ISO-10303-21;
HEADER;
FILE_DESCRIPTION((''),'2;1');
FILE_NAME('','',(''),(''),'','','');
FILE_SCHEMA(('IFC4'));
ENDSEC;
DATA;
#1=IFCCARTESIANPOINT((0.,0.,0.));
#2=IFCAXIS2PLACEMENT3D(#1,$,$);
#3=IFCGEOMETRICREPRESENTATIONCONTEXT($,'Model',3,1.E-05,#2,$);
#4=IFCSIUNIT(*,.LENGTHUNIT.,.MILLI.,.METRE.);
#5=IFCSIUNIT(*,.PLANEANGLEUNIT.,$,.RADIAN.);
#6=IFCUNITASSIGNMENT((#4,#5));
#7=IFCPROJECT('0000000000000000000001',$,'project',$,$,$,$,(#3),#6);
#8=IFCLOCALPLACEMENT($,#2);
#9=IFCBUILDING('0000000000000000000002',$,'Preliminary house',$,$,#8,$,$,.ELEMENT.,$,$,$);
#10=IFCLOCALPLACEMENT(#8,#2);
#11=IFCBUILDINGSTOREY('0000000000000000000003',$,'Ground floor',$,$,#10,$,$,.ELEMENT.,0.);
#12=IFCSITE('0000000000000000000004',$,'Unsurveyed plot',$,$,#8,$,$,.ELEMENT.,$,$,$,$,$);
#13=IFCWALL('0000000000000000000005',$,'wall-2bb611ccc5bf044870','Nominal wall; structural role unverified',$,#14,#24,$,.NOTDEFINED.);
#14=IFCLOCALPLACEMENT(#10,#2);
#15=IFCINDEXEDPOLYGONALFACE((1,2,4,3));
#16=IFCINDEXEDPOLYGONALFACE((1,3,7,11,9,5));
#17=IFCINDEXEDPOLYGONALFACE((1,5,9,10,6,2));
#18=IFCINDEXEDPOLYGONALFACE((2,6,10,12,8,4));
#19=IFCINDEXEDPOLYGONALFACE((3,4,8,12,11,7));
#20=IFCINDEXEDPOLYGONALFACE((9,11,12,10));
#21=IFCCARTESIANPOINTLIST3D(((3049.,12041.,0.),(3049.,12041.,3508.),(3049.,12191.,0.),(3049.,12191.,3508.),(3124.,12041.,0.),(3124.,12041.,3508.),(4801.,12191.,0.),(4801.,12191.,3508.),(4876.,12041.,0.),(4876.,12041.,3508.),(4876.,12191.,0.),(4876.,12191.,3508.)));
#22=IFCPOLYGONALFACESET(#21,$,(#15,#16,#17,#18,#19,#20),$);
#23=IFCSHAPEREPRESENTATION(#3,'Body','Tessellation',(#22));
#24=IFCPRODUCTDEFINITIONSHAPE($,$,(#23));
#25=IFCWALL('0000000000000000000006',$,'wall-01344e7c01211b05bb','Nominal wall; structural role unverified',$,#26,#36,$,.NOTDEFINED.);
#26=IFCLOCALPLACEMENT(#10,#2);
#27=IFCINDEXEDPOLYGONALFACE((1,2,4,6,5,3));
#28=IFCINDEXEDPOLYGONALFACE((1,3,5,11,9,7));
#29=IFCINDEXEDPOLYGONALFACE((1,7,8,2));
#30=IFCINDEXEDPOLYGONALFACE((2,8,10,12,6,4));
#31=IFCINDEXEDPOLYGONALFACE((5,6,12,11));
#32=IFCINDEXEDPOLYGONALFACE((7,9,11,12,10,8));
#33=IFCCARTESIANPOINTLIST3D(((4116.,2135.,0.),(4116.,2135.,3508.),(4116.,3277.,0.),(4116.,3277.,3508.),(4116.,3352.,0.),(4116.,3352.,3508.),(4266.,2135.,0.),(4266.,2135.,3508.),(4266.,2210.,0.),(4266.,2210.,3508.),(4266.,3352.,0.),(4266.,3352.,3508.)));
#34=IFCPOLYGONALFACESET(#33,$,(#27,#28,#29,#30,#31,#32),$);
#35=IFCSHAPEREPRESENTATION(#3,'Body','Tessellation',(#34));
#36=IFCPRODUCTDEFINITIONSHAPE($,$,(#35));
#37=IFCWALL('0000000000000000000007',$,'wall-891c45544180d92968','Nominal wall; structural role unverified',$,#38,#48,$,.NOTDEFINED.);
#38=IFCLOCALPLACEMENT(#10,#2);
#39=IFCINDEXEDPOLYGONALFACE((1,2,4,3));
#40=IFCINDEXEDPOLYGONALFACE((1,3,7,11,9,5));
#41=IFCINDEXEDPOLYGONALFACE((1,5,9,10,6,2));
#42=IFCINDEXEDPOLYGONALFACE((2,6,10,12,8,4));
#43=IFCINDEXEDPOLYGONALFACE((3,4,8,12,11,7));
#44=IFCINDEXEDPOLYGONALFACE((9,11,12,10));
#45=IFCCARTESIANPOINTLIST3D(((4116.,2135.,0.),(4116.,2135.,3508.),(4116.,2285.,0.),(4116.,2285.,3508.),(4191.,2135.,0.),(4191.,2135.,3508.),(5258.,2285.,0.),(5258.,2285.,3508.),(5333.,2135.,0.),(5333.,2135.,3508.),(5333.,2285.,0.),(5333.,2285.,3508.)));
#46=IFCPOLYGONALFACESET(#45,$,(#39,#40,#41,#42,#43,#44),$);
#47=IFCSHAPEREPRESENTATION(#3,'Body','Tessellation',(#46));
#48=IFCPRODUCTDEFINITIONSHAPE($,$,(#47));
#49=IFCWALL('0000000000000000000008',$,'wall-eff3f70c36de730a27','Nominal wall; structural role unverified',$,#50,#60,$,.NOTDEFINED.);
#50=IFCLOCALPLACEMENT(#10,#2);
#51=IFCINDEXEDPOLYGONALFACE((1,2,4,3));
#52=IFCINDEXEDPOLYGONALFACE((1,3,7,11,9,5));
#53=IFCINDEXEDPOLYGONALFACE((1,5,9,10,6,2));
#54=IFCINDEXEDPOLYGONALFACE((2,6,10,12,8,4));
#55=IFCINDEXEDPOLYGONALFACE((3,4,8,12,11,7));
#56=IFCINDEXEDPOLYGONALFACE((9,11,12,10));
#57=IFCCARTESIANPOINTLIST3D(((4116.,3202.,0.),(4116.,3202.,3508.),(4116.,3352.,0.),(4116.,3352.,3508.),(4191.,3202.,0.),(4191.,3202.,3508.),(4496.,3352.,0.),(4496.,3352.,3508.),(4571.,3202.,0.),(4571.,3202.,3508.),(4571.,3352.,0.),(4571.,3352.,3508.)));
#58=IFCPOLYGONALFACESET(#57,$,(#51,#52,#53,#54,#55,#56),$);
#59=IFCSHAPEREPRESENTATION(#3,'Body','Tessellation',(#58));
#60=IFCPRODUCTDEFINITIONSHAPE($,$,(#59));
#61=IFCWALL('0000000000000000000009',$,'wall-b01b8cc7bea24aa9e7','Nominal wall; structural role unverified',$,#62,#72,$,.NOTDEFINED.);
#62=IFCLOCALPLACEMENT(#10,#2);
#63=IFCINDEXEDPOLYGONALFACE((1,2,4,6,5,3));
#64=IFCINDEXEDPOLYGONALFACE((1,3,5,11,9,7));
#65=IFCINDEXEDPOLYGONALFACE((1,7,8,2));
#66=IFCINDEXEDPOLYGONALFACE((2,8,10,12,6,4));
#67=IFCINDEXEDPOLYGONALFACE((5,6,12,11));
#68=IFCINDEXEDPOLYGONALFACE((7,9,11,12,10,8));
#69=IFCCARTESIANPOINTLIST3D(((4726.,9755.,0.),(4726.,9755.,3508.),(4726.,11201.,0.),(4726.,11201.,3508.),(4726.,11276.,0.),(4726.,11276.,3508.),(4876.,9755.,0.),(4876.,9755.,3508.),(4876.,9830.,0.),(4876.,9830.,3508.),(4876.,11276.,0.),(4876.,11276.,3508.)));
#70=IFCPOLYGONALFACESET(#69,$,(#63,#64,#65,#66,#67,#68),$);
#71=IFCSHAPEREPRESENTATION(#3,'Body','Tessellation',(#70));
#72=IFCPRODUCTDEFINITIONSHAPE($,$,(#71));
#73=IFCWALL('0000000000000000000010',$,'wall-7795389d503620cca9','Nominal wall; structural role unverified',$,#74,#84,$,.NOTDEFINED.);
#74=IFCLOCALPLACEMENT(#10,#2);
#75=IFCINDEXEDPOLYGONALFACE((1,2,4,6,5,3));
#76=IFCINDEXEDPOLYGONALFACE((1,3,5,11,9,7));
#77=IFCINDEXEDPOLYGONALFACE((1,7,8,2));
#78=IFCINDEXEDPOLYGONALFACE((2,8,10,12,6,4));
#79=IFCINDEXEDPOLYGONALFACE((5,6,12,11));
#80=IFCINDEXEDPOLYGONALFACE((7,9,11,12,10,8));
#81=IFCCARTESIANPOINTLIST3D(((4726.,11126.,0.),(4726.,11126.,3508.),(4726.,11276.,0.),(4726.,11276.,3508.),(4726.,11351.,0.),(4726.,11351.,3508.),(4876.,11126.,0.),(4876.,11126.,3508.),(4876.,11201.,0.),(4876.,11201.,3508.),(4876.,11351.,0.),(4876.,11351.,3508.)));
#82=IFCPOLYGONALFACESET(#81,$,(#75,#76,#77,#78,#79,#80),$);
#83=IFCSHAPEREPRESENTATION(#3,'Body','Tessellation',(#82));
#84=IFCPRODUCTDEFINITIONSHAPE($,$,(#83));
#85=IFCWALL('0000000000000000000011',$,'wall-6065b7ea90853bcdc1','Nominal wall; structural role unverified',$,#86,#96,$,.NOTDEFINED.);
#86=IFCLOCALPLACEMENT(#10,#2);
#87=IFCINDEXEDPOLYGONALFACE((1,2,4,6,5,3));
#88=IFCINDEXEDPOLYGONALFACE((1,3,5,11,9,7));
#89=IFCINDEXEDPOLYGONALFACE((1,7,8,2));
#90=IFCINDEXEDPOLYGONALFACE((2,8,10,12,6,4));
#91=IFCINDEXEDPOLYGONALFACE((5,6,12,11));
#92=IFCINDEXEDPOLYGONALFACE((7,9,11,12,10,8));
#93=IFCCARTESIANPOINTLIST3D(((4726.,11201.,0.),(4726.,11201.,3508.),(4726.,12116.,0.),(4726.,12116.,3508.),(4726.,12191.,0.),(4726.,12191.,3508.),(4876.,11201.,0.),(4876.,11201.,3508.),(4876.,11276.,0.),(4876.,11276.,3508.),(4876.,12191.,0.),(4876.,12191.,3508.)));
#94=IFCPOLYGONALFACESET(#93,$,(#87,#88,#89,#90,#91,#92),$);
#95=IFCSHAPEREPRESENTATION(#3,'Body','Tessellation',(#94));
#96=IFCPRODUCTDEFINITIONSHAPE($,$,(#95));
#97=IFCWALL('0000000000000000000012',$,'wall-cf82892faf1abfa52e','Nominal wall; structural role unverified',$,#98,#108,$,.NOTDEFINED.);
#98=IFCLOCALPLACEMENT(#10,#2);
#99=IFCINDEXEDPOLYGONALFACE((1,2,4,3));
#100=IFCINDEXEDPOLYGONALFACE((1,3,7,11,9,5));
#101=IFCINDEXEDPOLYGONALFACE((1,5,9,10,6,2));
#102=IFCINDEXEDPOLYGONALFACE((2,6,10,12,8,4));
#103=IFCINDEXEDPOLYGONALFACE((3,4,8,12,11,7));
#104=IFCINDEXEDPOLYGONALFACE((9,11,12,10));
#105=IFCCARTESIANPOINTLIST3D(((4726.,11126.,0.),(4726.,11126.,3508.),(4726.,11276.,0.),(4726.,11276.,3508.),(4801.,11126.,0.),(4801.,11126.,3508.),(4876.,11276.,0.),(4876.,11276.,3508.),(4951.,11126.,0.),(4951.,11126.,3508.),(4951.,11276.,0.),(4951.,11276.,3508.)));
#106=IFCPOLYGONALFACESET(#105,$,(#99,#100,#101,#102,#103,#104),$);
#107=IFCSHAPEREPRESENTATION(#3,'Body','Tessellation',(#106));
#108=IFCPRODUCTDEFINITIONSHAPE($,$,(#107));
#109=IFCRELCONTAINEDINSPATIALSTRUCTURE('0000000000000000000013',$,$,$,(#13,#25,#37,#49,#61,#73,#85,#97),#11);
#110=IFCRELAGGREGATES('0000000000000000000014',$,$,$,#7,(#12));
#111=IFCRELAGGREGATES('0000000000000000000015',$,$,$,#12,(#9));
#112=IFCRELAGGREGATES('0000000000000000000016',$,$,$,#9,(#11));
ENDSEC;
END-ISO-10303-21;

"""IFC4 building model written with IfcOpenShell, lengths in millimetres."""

from ifc_helpers import new_model, si_unit, origin, place, context, project, spatial, polyline, outline, extrude, element, save


model = new_model("IFC4")

# Units and contexts
model_context = context("Model", 3, precision=1e-05, world=origin())
ifc_project = project(units=[si_unit("LENGTHUNIT", "METRE", prefix="MILLI"), si_unit("PLANEANGLEUNIT", "RADIAN")], contexts=[model_context])

# Site, building, storey
placement_1 = place(None, origin())
site = spatial("IfcSite", under=ifc_project, at=placement_1, Name="Unsurveyed plot", CompositionType="ELEMENT")
building = spatial("IfcBuilding", under=site, at=placement_1, Name="Preliminary house", CompositionType="ELEMENT")
placement_2 = place(placement_1, origin())
storey = spatial("IfcBuildingStorey", under=building, at=placement_2, Name="Ground floor", CompositionType="ELEMENT", Elevation=0.0)

# Wall
element("IfcWall", 1, at=placement_2, inside=storey, Name="wall-2bb611ccc5bf044870", Description="Nominal wall; structural role unverified", PredefinedType="NOTDEFINED", context=model_context, shape_type="SweptSolid", body=[
    extrude(outline(polyline([(4801.0, 12191.0), (4876.0, 12191.0), (4876.0, 12041.0), (3124.0, 12041.0), (3049.0, 12041.0), (3049.0, 12191.0), (4801.0, 12191.0)])), origin(), (0.0, 0.0, 1.0), 3508.0),
])

# Walls
element("IfcWall", 2, at=placement_2, inside=storey, Name="wall-01344e7c01211b05bb", Description="Nominal wall; structural role unverified", PredefinedType="NOTDEFINED", context=model_context, shape_type="SweptSolid", body=[
    extrude(outline(polyline([(4116.0, 3277.0), (4116.0, 3352.0), (4266.0, 3352.0), (4266.0, 2210.0), (4266.0, 2135.0), (4116.0, 2135.0), (4116.0, 3277.0)])), origin(), (0.0, 0.0, 1.0), 3508.0),
])
element("IfcWall", 3, at=placement_2, inside=storey, Name="wall-891c45544180d92968", Description="Nominal wall; structural role unverified", PredefinedType="NOTDEFINED", context=model_context, shape_type="SweptSolid", body=[
    extrude(outline(polyline([(5258.0, 2285.0), (5333.0, 2285.0), (5333.0, 2135.0), (4191.0, 2135.0), (4116.0, 2135.0), (4116.0, 2285.0), (5258.0, 2285.0)])), origin(), (0.0, 0.0, 1.0), 3508.0),
])
element("IfcWall", 4, at=placement_2, inside=storey, Name="wall-eff3f70c36de730a27", Description="Nominal wall; structural role unverified", PredefinedType="NOTDEFINED", context=model_context, shape_type="SweptSolid", body=[
    extrude(outline(polyline([(4496.0, 3352.0), (4571.0, 3352.0), (4571.0, 3202.0), (4191.0, 3202.0), (4116.0, 3202.0), (4116.0, 3352.0), (4496.0, 3352.0)])), origin(), (0.0, 0.0, 1.0), 3508.0),
])

# Wall
element("IfcWall", 5, at=placement_2, inside=storey, Name="wall-b01b8cc7bea24aa9e7", Description="Nominal wall; structural role unverified", PredefinedType="NOTDEFINED", context=model_context, shape_type="SweptSolid", body=[
    extrude(outline(polyline([(4726.0, 11201.0), (4726.0, 11276.0), (4876.0, 11276.0), (4876.0, 9830.0), (4876.0, 9755.0), (4726.0, 9755.0), (4726.0, 11201.0)])), origin(), (0.0, 0.0, 1.0), 3508.0),
])

# Walls
element("IfcWall", 6, at=placement_2, inside=storey, Name="wall-7795389d503620cca9", Description="Nominal wall; structural role unverified", PredefinedType="NOTDEFINED", context=model_context, shape_type="SweptSolid", body=[
    extrude(outline(polyline([(4726.0, 11276.0), (4726.0, 11351.0), (4876.0, 11351.0), (4876.0, 11201.0), (4876.0, 11126.0), (4726.0, 11126.0), (4726.0, 11276.0)])), origin(), (0.0, 0.0, 1.0), 3508.0),
])
element("IfcWall", 7, at=placement_2, inside=storey, Name="wall-6065b7ea90853bcdc1", Description="Nominal wall; structural role unverified", PredefinedType="NOTDEFINED", context=model_context, shape_type="SweptSolid", body=[
    extrude(outline(polyline([(4726.0, 12116.0), (4726.0, 12191.0), (4876.0, 12191.0), (4876.0, 11276.0), (4876.0, 11201.0), (4726.0, 11201.0), (4726.0, 12116.0)])), origin(), (0.0, 0.0, 1.0), 3508.0),
])
element("IfcWall", 8, at=placement_2, inside=storey, Name="wall-cf82892faf1abfa52e", Description="Nominal wall; structural role unverified", PredefinedType="NOTDEFINED", context=model_context, shape_type="SweptSolid", body=[
    extrude(outline(polyline([(4876.0, 11276.0), (4951.0, 11276.0), (4951.0, 11126.0), (4801.0, 11126.0), (4726.0, 11126.0), (4726.0, 11276.0), (4876.0, 11276.0)])), origin(), (0.0, 0.0, 1.0), 3508.0),
])

save(model, "model.ifc")
